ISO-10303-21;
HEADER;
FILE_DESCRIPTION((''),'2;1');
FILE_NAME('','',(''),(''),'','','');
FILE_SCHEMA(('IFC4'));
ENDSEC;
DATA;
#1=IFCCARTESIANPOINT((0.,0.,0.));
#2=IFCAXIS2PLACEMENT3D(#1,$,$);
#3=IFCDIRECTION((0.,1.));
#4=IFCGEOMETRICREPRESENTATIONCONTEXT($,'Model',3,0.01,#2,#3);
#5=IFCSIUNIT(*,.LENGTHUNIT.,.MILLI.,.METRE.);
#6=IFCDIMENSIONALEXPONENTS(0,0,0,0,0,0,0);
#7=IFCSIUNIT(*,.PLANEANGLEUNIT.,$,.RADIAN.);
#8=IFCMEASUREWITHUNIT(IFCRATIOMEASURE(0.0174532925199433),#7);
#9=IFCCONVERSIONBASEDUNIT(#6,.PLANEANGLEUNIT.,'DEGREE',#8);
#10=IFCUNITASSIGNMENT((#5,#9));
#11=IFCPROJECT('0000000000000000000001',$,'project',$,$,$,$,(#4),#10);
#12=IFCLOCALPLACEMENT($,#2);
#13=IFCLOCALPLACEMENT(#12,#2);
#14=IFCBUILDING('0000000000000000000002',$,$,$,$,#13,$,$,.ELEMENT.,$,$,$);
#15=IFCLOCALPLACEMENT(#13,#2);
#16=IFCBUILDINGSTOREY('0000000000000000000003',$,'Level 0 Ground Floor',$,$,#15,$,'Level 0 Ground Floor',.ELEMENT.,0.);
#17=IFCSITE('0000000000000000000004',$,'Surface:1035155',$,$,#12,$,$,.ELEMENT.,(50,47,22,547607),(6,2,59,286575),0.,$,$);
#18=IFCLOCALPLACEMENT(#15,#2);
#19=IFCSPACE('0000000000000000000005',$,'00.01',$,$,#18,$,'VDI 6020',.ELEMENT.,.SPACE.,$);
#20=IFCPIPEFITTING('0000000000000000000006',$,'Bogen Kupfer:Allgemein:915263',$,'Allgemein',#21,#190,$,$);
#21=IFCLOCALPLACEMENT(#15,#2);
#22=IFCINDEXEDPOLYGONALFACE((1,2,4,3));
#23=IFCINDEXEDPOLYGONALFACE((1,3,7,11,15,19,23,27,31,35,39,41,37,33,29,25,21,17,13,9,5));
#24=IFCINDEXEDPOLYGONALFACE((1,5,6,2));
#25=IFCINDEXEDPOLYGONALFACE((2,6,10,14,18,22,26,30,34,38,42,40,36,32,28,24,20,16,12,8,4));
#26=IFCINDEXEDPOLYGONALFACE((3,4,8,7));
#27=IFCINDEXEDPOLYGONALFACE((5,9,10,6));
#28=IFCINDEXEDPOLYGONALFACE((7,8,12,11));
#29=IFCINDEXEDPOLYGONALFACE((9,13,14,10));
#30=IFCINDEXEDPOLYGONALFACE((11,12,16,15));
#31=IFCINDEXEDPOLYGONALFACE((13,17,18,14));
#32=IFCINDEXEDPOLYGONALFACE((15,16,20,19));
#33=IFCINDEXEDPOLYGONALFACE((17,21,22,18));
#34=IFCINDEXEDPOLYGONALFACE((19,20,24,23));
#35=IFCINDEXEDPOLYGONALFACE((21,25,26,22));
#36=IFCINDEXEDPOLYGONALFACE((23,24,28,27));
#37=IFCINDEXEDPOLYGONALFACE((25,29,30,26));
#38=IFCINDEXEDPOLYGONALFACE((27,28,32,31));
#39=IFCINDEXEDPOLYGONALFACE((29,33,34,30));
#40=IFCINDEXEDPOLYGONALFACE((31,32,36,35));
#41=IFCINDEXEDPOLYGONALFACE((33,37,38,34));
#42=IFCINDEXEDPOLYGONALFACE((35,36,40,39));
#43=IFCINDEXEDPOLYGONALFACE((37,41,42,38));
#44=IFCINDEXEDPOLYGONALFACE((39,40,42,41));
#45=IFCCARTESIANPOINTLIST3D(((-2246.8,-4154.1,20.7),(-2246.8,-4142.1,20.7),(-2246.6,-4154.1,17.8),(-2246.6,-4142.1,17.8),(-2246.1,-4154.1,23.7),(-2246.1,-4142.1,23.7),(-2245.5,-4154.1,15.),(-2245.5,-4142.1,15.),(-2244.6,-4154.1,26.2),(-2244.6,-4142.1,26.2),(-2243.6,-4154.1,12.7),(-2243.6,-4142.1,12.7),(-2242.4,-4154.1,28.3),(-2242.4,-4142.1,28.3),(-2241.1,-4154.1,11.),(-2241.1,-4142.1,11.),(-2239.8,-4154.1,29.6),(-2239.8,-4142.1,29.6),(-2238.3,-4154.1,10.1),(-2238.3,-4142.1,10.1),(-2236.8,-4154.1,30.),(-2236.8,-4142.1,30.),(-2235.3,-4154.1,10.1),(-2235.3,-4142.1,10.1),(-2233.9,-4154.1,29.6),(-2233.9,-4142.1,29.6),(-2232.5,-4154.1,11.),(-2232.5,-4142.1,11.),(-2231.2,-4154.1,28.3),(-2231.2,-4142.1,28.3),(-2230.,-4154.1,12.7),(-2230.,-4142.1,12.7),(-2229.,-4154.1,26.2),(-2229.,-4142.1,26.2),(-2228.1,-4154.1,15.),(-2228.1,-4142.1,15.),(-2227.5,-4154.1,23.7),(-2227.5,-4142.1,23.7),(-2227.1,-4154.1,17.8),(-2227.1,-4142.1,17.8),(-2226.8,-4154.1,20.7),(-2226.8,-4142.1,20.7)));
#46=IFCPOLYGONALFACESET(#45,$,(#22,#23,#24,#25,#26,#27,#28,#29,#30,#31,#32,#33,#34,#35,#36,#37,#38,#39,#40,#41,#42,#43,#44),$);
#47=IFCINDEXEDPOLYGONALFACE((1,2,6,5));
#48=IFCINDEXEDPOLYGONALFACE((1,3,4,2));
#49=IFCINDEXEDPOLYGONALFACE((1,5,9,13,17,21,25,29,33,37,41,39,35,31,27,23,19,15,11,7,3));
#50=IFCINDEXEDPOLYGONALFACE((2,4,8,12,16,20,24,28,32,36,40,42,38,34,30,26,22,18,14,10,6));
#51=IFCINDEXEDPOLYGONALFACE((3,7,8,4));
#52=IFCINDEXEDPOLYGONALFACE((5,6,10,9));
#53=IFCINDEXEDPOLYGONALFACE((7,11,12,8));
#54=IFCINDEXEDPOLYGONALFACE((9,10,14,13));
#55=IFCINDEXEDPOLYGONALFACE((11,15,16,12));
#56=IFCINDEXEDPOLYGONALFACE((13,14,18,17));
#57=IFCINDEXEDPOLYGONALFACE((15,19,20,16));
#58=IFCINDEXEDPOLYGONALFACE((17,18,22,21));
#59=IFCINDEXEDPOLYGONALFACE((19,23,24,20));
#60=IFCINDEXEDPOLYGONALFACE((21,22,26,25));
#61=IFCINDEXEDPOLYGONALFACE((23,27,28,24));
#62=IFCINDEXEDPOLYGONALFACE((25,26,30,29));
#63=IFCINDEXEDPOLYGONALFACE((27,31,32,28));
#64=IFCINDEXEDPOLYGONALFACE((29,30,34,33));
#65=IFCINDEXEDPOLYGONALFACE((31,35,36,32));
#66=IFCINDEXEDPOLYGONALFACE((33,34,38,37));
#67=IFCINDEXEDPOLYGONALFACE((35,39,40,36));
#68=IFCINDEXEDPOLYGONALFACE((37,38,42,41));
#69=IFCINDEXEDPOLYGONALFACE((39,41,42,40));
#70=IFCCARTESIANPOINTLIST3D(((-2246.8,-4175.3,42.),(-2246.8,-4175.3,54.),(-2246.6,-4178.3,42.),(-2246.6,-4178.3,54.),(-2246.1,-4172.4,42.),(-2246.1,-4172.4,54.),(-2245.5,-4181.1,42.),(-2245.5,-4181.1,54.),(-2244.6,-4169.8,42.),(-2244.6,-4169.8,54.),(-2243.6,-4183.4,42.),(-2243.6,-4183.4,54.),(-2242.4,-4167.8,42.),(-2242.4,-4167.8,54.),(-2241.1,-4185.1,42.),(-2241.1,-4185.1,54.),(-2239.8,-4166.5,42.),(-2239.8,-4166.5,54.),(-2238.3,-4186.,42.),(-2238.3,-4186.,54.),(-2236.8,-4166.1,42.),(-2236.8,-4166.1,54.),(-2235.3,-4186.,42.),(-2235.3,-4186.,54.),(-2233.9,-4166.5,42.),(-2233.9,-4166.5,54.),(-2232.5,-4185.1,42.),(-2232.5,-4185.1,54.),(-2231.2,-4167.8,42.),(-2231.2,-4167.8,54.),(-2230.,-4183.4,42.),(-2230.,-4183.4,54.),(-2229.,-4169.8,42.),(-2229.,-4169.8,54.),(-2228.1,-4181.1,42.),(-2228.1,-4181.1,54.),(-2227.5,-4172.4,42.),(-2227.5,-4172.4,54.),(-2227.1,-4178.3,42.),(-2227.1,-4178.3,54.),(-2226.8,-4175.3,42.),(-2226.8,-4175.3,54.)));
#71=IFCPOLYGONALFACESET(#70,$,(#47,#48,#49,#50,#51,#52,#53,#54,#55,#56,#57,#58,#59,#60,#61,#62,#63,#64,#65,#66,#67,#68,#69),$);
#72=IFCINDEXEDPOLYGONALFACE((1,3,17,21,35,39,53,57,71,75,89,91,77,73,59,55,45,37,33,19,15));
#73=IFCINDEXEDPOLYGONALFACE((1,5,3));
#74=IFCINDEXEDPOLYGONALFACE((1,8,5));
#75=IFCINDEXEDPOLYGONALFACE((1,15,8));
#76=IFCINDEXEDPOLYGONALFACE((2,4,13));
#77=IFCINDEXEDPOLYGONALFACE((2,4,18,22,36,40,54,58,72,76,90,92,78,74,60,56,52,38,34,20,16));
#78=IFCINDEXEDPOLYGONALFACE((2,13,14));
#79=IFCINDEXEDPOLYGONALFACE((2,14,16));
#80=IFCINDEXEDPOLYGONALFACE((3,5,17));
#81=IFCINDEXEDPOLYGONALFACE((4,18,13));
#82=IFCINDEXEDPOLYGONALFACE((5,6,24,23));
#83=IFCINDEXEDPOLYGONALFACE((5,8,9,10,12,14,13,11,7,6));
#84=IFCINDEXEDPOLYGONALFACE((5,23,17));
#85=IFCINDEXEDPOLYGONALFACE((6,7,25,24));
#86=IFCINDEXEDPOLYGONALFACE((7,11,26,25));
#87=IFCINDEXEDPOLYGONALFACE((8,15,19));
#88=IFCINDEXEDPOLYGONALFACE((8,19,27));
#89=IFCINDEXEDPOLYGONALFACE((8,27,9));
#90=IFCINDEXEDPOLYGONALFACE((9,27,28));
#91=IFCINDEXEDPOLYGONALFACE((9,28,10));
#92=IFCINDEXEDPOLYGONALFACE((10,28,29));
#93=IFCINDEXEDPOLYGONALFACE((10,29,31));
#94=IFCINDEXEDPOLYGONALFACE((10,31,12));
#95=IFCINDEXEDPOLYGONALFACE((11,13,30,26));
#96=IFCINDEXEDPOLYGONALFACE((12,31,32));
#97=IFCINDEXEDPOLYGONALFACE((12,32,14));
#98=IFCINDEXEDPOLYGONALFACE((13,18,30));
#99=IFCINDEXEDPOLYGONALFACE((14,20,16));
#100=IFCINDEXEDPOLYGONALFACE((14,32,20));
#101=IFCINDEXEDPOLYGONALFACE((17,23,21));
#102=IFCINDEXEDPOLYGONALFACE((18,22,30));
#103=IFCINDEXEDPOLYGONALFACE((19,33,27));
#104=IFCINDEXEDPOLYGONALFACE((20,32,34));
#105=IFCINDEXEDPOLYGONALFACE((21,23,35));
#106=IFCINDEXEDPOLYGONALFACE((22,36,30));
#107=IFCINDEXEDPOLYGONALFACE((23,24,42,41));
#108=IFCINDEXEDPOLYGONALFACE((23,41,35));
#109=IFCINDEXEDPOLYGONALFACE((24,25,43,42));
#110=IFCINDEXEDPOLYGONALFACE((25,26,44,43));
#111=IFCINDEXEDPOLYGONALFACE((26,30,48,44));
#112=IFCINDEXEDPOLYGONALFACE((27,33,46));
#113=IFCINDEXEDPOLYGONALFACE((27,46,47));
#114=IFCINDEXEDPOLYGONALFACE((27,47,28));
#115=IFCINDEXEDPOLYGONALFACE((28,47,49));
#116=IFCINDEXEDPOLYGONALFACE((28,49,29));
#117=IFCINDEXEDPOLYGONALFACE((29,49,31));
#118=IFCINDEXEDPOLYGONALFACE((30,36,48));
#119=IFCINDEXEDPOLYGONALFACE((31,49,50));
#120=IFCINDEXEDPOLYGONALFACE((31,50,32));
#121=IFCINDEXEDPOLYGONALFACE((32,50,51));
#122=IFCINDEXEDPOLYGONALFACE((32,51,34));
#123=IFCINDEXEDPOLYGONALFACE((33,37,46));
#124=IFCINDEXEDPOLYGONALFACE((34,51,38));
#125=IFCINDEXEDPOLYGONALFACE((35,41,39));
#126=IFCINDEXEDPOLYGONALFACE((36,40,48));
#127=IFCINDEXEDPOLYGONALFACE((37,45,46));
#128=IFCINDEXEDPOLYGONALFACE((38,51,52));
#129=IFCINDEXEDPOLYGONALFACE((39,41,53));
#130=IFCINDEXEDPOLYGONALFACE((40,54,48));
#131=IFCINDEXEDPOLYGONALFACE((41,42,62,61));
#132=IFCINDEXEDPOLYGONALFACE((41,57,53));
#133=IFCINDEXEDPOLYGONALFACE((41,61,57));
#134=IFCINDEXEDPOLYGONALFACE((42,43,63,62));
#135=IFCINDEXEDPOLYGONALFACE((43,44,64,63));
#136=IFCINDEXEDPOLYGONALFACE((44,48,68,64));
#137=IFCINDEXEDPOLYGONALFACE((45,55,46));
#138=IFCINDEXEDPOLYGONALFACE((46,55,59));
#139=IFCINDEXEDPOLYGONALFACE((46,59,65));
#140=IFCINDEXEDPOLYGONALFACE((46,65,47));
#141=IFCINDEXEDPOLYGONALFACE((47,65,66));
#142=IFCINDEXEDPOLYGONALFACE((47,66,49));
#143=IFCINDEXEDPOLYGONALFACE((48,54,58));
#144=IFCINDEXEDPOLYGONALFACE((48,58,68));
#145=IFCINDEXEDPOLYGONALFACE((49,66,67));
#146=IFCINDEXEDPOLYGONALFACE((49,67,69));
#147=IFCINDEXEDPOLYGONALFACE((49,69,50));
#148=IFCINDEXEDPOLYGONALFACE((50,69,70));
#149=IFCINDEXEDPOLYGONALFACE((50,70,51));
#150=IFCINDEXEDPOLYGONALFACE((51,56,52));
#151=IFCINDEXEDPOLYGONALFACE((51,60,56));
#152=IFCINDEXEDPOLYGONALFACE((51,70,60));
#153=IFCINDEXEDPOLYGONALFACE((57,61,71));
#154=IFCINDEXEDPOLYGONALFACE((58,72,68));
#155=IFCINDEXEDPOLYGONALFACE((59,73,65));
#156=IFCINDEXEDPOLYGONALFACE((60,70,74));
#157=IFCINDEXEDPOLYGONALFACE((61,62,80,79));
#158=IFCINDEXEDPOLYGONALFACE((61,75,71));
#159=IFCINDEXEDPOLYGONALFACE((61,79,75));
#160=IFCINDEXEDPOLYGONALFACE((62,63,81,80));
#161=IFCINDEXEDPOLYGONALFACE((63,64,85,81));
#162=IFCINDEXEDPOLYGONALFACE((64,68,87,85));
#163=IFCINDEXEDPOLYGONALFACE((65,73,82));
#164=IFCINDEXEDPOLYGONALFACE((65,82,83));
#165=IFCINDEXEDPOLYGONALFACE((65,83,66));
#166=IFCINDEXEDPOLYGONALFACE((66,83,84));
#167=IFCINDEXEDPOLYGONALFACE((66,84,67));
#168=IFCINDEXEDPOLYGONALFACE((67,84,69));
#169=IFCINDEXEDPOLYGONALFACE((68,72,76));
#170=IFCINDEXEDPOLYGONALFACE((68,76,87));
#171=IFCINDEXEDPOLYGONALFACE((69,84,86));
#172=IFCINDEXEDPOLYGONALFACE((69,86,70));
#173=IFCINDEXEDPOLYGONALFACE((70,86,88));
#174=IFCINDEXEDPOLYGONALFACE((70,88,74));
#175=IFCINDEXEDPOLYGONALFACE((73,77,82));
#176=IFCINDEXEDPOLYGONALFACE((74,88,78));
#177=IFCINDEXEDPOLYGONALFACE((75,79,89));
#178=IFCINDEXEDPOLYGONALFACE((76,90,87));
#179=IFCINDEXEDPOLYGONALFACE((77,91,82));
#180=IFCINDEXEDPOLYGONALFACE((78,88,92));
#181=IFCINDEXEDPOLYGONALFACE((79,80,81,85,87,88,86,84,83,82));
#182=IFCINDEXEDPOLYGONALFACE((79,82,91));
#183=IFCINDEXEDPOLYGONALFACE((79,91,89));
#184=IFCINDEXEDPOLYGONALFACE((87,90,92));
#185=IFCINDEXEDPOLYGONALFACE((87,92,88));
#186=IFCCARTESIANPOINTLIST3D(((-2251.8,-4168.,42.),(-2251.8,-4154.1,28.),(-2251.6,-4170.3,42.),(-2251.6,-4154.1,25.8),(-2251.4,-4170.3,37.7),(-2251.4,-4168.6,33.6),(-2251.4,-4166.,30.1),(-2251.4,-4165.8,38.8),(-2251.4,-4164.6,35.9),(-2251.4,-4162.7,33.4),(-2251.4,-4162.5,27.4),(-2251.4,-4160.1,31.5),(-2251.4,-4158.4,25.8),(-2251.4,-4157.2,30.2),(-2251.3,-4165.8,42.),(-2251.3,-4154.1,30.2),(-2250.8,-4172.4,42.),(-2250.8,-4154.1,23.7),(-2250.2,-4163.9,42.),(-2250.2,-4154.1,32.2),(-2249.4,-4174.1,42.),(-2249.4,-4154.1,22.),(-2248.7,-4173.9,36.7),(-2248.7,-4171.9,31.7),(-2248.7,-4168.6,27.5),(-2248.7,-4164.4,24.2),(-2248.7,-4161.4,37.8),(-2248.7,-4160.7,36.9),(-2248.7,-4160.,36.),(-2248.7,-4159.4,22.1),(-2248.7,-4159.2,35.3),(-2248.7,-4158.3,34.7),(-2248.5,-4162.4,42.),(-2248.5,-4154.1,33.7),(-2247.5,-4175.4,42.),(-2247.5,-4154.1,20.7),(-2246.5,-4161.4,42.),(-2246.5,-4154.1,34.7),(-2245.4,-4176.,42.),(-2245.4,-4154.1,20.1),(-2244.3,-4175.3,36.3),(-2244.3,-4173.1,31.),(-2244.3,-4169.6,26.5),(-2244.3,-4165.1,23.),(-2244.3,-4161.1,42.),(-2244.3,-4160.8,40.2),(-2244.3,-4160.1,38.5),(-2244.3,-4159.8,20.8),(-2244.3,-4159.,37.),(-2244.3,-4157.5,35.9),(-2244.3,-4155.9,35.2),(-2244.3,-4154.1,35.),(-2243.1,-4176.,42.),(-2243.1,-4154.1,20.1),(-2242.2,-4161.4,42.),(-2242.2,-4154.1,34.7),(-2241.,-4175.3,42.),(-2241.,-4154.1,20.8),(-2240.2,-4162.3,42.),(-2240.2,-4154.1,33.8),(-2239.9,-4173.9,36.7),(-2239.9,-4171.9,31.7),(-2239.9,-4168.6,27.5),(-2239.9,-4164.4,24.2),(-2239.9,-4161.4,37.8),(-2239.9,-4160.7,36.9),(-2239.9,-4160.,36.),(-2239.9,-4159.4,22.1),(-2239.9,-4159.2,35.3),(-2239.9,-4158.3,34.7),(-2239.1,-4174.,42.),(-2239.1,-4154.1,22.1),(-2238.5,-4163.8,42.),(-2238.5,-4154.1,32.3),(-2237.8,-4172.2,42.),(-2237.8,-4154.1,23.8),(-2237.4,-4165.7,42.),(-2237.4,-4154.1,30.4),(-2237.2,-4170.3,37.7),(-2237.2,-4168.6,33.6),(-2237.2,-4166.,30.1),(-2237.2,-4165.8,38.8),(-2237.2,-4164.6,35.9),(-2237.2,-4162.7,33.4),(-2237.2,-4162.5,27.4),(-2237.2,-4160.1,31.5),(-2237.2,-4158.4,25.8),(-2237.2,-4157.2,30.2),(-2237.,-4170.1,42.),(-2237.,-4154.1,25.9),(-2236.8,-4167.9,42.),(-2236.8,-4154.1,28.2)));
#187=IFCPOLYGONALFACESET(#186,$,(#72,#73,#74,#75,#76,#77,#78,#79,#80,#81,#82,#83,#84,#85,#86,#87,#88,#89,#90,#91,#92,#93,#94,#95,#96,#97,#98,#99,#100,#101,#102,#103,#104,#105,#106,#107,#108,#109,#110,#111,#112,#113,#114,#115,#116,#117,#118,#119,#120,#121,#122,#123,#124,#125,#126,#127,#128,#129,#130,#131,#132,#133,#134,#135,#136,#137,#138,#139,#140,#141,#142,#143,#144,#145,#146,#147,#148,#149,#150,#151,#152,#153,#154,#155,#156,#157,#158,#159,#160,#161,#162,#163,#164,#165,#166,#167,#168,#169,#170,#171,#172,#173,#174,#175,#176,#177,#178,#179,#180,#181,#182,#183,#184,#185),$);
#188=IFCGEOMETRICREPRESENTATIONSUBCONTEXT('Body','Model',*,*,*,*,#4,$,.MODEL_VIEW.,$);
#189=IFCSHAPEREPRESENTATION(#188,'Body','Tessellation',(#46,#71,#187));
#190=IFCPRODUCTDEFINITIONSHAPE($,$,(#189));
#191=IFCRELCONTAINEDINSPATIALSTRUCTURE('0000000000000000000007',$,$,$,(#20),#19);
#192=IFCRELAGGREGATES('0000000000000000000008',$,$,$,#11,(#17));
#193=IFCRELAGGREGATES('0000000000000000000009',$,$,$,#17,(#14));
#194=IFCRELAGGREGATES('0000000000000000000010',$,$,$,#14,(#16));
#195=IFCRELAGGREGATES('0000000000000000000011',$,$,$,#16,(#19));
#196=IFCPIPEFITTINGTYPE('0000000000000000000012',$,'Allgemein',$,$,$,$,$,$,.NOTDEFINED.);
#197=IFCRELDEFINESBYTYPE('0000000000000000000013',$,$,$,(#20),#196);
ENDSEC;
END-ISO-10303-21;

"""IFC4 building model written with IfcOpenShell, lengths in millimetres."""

from ifc_helpers import new_model, entity, si_unit, converted_unit, direction, frame, frame_2d, origin, place, context, subcontext, project, spatial, circle, extrude, source, transform, mapped, type_object, type_shapes, element, save


model = new_model("IFC4")

# Units and contexts
model_context = context("Model", 3, precision=0.01, world=origin(), true_north=direction((0.0, 1.0)))
body_context = subcontext(model_context, "Body", "Model", "MODEL_VIEW")
ifc_project = project(units=[si_unit("LENGTHUNIT", "METRE", prefix="MILLI"), converted_unit("PLANEANGLEUNIT", "DEGREE", entity("IfcRatioMeasure", 0.0174532925199433), si_unit("PLANEANGLEUNIT", "RADIAN"), dimensions=[0, 0, 0, 0, 0, 0, 0])], contexts=[model_context])

# Site, building, storey
site_placement = place(None, origin())
site = spatial("IfcSite", under=ifc_project, at=site_placement, Name="Surface:1035155", CompositionType="ELEMENT", RefLatitude=(50, 47, 22, 547607), RefLongitude=(6, 2, 59, 286575), RefElevation=0.0)
building_placement = place(site_placement, origin())
building = spatial("IfcBuilding", under=site, at=building_placement, CompositionType="ELEMENT")
storey_placement = place(building_placement, origin())
storey = spatial("IfcBuildingStorey", under=building, at=storey_placement, Name="Level 0 Ground Floor", LongName="Level 0 Ground Floor", CompositionType="ELEMENT", Elevation=0.0)

# Shared definitions
pipe_fitting_type = type_object("IfcPipeFittingType", Name="Allgemein", PredefinedType="NOTDEFINED")
ifc_direction = entity("IfcDirection", [0.0, 0.0, -1.0])
trimmed_curve = entity("IfcTrimmedCurve", entity("IfcCircle", entity("IfcAxis2Placement2D", entity("IfcCartesianPoint", [-14.5, 0.0]), entity("IfcDirection", [0.0, 1.0])), 14.5), [entity("IfcParameterValue", 270.0)], [entity("IfcParameterValue", 0.0)], True, "PARAMETER")
shared_shape_1 = source(origin(), body_context, "Body", "SolidModel", [
    extrude(circle(Radius=10.0, at=frame_2d((0.0, 0.0), x_axis=(1.0, 0.0))), frame((0.0, 22.0, 0.0), z_axis=(0.0, 1.0, 0.0), x_axis=(-1.0, 0.0, 0.0)), (0.0, 0.0, 1.0), 12.0),
    extrude(circle(Radius=10.0, at=frame_2d((0.0, 0.0), x_axis=(1.0, 0.0))), frame((-34.0, 0.0, 0.0), z_axis=(1.0, 0.0, 0.0), x_axis=(0.0, 1.0, 0.0)), (0.0, 0.0, 1.0), 12.0),
    entity("IfcSurfaceCurveSweptAreaSolid", entity("IfcCircleProfileDef", "AREA", None, entity("IfcAxis2Placement2D", entity("IfcCartesianPoint", [0.0, 7.5]), entity("IfcDirection", [1.0, 0.0])), 7.5), entity("IfcAxis2Placement3D", entity("IfcCartesianPoint", [-7.5, 22.0, 0.0]), ifc_direction, entity("IfcDirection", [1.0, 0.0, 0.0])), trimmed_curve, 0.0, 90.0, entity("IfcSurfaceOfLinearExtrusion", entity("IfcArbitraryOpenProfileDef", "CURVE", None, trimmed_curve), entity("IfcAxis2Placement3D", entity("IfcCartesianPoint", [0.0, 0.0, -304.8])), ifc_direction, 1.0)),
])
type_shapes(pipe_fitting_type, [shared_shape_1])

# Shared definitions
space_placement = place(storey_placement, origin())
space = spatial("IfcSpace", under=storey, at=space_placement, Name="00.01", LongName="VDI 6020", CompositionType="ELEMENT", PredefinedType="SPACE")

# Pipe fitting
for number, where, z_axis, x_axis, name in (
    (1, (-2236.8, -4176.1, 20.0), (1.0, 0.0, 0.0), (0.0, 0.0, -1.0), "Bogen Kupfer:Allgemein:915263"),
):
    element("IfcPipeFitting", number, at=place(space_placement, frame(where, z_axis=z_axis, x_axis=x_axis)), inside=space, type_object=pipe_fitting_type, Name=name, ObjectType="Allgemein", context=body_context, shape_type="MappedRepresentation", body=[
        mapped(shared_shape_1, transform((0.0, 0.0, 0.0), scale=1.0)),
    ])

save(model, "model.ifc")
